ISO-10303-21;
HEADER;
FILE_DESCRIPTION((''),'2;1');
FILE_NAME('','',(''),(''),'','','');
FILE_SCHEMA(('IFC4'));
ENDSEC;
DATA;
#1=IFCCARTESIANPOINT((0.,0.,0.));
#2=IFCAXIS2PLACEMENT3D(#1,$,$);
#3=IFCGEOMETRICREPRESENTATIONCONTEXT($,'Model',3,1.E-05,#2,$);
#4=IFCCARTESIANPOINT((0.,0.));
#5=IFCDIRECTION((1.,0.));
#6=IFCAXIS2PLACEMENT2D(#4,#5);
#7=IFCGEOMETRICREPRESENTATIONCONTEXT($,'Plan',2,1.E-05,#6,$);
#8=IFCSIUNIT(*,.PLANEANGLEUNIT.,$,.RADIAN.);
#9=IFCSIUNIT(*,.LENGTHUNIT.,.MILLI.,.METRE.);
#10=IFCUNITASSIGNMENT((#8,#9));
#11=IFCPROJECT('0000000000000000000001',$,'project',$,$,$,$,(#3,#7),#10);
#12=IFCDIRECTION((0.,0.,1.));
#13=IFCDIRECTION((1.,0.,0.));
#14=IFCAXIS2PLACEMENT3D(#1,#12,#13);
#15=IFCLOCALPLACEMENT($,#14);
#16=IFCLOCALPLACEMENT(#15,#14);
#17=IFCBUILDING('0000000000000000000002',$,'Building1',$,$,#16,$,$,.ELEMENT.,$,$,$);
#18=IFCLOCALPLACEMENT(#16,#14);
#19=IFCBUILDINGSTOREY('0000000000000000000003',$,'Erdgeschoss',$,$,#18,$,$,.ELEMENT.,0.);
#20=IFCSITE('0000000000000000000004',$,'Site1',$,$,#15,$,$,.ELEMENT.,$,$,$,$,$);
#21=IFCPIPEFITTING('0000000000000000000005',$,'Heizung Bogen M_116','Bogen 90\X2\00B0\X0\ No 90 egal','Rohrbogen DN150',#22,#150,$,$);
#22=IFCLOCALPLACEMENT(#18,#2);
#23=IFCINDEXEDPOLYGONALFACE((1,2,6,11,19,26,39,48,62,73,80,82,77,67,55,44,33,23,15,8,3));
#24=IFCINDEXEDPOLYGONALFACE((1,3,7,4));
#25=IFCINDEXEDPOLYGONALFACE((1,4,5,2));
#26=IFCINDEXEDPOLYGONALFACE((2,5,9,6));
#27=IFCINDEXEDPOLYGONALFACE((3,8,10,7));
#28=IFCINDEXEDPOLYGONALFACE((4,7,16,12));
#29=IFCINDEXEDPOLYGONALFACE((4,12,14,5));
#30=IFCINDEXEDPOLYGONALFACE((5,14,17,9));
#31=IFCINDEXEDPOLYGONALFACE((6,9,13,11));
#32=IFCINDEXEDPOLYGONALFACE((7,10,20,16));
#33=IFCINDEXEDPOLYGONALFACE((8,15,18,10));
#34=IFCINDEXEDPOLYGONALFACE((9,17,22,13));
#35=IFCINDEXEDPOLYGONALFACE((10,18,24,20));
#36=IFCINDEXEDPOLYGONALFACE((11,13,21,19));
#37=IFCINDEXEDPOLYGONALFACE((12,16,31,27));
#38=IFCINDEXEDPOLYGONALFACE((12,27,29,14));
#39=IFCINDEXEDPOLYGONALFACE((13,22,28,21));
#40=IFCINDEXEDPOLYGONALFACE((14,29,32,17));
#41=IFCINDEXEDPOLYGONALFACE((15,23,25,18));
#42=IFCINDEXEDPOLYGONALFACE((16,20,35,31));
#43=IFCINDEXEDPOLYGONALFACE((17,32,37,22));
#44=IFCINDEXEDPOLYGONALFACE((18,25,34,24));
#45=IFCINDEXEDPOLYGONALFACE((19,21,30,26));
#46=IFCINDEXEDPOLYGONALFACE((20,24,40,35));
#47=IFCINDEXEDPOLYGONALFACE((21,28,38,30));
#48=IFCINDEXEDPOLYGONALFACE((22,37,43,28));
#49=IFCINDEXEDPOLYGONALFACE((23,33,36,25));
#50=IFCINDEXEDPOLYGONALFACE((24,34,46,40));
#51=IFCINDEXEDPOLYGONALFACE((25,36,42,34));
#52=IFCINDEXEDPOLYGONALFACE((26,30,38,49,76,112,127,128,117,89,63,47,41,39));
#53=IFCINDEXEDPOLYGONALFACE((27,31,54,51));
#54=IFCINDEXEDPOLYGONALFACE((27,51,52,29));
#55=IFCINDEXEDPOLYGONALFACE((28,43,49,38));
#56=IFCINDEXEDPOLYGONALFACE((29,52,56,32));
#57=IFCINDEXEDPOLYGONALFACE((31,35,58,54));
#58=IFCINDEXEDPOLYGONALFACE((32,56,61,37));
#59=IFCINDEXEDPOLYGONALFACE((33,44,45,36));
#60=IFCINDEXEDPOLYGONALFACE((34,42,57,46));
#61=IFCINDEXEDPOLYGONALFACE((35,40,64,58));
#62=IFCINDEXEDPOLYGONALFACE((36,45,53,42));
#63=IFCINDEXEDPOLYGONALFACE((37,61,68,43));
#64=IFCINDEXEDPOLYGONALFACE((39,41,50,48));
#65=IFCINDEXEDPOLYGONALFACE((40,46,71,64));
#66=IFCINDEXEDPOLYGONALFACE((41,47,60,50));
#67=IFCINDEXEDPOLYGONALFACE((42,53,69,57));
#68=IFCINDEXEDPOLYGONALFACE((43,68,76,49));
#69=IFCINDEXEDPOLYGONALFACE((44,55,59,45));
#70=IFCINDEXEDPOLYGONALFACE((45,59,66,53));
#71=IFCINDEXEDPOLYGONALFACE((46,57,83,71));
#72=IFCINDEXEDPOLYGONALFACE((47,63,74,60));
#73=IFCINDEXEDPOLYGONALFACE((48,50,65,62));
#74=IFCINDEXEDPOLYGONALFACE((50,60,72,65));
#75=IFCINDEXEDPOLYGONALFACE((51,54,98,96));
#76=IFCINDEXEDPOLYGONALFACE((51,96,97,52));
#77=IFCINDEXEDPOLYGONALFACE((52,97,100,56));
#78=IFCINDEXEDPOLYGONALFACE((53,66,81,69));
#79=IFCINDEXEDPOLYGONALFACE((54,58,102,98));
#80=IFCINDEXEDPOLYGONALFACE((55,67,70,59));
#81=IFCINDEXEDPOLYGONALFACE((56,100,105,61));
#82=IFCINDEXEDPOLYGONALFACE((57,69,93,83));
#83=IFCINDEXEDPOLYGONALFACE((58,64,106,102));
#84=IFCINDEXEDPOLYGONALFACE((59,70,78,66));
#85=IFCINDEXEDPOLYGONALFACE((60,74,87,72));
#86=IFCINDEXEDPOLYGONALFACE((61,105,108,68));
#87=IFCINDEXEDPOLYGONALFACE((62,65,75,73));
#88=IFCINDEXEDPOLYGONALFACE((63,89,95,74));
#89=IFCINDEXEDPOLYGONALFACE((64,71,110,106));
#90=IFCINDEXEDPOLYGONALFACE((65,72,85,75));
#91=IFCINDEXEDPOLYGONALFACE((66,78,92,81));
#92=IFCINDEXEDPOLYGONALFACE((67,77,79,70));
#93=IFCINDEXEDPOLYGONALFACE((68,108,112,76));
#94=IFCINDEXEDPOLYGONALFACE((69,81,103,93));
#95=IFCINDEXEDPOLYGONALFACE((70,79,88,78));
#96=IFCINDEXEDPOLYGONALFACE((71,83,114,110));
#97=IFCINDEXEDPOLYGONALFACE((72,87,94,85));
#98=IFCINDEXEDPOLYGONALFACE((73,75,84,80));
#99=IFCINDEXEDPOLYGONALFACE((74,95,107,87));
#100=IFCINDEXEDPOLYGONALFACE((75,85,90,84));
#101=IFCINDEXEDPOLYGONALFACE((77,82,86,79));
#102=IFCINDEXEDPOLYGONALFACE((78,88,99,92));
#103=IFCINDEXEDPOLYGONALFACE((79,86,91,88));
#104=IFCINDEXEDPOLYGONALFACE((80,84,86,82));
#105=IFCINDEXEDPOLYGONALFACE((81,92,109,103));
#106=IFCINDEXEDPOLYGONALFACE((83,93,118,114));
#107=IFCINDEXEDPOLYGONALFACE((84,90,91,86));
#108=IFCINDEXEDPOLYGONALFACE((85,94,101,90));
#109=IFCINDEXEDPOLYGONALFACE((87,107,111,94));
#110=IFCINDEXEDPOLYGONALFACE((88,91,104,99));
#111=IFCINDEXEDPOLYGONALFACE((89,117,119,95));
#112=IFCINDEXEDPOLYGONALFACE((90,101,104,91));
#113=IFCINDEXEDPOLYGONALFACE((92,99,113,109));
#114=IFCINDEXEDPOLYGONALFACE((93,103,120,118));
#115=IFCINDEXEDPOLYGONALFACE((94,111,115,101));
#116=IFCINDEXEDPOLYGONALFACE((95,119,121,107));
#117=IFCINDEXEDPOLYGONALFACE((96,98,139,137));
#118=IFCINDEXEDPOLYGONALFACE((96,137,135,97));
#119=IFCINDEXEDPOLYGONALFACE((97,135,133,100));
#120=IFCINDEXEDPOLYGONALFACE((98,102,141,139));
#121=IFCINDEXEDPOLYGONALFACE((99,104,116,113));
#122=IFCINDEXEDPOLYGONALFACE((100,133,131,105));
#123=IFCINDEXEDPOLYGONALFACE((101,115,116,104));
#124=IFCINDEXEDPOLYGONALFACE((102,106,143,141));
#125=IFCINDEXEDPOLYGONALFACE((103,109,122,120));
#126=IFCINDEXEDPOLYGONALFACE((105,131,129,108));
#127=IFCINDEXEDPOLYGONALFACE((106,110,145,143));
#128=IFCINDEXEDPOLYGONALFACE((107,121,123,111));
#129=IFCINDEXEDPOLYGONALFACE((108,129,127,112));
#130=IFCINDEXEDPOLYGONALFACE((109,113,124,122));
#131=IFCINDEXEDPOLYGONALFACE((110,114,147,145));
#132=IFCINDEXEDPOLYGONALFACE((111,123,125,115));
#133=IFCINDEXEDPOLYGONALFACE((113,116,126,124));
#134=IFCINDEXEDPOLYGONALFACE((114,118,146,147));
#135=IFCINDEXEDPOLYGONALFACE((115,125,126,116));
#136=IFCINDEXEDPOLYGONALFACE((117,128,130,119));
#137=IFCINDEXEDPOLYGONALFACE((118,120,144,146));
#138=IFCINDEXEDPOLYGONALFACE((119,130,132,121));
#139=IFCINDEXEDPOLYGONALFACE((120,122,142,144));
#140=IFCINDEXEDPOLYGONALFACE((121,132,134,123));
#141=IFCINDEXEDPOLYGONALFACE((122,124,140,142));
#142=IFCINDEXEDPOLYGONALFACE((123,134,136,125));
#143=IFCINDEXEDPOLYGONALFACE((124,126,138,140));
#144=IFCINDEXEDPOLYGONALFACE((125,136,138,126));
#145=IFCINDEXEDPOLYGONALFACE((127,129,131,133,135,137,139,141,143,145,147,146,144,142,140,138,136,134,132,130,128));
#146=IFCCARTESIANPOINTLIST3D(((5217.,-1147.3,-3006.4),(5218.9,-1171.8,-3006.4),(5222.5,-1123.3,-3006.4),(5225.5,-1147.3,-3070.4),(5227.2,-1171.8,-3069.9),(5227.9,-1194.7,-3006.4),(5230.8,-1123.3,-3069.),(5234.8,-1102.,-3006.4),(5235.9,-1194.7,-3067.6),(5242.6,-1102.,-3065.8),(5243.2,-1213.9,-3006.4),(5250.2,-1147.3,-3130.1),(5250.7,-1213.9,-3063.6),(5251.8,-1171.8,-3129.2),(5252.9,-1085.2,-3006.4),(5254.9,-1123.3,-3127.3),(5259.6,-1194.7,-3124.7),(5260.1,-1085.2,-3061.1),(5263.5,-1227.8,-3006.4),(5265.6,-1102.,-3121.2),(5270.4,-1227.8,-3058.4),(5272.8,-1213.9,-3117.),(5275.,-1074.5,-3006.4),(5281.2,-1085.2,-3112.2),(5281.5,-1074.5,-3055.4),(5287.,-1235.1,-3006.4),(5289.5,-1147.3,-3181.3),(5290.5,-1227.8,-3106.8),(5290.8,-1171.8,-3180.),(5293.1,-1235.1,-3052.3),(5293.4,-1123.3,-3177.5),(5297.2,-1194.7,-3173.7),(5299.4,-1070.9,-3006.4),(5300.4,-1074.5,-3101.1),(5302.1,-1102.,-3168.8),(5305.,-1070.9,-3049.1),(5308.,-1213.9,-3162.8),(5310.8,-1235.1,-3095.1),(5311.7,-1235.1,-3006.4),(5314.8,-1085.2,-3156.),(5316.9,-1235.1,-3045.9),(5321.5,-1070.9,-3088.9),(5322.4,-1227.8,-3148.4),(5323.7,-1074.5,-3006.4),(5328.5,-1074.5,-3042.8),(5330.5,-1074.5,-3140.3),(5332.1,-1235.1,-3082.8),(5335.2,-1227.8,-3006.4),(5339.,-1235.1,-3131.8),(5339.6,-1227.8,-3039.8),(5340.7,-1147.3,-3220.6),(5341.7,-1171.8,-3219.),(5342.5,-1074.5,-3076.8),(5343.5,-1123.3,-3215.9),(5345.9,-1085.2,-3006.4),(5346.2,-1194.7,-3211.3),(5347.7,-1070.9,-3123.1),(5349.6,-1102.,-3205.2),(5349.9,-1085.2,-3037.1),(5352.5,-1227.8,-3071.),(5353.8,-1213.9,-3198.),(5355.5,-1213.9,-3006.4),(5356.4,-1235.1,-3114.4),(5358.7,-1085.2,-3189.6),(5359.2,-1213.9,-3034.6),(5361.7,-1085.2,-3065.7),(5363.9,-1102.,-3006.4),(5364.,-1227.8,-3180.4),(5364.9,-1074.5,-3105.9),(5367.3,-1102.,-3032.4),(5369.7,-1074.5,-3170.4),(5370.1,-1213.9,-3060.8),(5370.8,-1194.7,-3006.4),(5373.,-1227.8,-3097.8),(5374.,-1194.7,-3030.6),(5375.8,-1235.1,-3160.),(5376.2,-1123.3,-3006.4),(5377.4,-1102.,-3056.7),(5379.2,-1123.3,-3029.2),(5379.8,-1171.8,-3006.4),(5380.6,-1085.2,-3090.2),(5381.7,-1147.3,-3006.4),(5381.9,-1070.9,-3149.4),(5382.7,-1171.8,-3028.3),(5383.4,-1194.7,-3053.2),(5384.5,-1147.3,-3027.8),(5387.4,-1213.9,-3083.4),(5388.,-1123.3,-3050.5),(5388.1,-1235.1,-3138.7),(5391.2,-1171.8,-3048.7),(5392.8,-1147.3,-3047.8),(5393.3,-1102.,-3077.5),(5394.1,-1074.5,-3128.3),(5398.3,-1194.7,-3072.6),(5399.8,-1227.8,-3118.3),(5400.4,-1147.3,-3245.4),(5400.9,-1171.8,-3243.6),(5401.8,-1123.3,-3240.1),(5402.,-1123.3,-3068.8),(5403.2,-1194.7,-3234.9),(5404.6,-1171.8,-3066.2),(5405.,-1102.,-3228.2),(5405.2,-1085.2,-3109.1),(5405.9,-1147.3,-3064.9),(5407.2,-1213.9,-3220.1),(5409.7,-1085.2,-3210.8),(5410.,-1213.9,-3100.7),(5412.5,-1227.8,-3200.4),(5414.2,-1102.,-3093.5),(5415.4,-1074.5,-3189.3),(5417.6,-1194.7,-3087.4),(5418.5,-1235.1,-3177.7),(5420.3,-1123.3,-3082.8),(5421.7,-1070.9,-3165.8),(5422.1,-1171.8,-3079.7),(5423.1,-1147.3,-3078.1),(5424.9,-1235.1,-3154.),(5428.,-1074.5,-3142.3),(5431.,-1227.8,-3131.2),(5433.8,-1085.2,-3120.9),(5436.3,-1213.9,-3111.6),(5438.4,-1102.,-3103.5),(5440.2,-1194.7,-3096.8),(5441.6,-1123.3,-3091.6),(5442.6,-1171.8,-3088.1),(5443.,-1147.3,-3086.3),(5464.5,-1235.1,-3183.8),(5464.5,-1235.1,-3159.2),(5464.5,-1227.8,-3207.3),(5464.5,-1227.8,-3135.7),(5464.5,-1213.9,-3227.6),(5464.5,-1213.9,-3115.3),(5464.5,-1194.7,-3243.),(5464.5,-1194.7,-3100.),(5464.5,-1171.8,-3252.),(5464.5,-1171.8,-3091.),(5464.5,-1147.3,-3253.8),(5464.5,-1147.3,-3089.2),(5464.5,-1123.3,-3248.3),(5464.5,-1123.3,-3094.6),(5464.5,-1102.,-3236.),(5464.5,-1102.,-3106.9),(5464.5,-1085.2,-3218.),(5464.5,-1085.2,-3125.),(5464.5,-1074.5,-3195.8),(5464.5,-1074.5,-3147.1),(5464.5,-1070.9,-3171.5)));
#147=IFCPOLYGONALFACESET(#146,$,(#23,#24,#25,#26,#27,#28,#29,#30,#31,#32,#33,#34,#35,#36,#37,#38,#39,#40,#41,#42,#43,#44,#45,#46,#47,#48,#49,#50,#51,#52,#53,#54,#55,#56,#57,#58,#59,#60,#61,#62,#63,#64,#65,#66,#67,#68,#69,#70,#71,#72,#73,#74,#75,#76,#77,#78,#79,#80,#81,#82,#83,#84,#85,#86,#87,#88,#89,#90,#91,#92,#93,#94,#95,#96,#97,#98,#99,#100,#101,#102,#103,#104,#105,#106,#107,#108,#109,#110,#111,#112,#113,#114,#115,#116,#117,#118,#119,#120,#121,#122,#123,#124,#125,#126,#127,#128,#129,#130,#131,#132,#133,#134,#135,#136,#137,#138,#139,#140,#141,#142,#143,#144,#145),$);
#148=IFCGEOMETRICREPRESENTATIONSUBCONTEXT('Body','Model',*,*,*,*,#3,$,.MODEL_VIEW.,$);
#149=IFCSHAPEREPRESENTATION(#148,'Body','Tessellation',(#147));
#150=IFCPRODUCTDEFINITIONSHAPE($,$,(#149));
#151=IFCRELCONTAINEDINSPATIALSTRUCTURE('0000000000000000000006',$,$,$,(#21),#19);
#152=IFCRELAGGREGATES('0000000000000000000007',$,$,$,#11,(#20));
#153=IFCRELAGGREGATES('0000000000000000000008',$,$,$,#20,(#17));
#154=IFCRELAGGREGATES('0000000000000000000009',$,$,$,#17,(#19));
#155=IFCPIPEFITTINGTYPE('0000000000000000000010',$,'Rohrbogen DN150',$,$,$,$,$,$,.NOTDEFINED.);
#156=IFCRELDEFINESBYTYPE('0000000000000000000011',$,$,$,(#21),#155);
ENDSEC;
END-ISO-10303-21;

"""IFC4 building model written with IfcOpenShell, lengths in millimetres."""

from ifc_helpers import new_model, entity, si_unit, frame, origin, origin_with_axes, origin_2d_with_axis, place, context, subcontext, project, spatial, source, transform, mapped, type_object, element, save


model = new_model("IFC4")

# Units and contexts
model_context = context("Model", 3, precision=1e-05, world=origin())
plan_context = context("Plan", 2, precision=1e-05, world=origin_2d_with_axis())
body_context = subcontext(model_context, "Body", "Model", "MODEL_VIEW")
ifc_project = project(units=[si_unit("PLANEANGLEUNIT", "RADIAN"), si_unit("LENGTHUNIT", "METRE", prefix="MILLI")], contexts=[model_context, plan_context])

# Site, building, storey
site_placement = place(None, origin_with_axes())
site = spatial("IfcSite", under=ifc_project, at=site_placement, Name="Site1", CompositionType="ELEMENT")
building_placement = place(site_placement, origin_with_axes())
building = spatial("IfcBuilding", under=site, at=building_placement, Name="Building1", CompositionType="ELEMENT")
storey_placement = place(building_placement, origin_with_axes())
storey = spatial("IfcBuildingStorey", under=building, at=storey_placement, Name="Erdgeschoss", CompositionType="ELEMENT", Elevation=0.0)

# Pipe fitting
pipe_fitting_type_1 = type_object("IfcPipeFittingType", Name="Rohrbogen DN150", PredefinedType="NOTDEFINED")
ifc_direction_1 = entity("IfcDirection", [-1.0, 0.0, 0.0])
shared_shape_1 = source(origin_with_axes(), body_context, "Body", "SolidModel", [
    entity("IfcRevolvedAreaSolid", entity("IfcCircleProfileDef", "AREA", None, entity("IfcAxis2Placement2D", entity("IfcCartesianPoint", [0.0, 0.0]), entity("IfcDirection", [1.0, 0.0])), 82.5), entity("IfcAxis2Placement3D", entity("IfcCartesianPoint", [123.8, -41.3, 0.0]), ifc_direction_1, entity("IfcDirection", [0.0, 0.0, 1.0])), entity("IfcAxis1Placement", entity("IfcCartesianPoint", [0.0, 165.1, 0.0]), ifc_direction_1), 1.570796),
])
pipe_fitting_1_placement = place(storey_placement, frame((5340.6, -1153.4, -3130.2), z_axis=(0.0, 0.0, 1.0), x_axis=(1.0, 0.0, 0.0)))
element("IfcPipeFitting", 1, at=pipe_fitting_1_placement, inside=storey, type_object=pipe_fitting_type_1, Name="Heizung Bogen M_116", Description="Bogen 90° No 90 egal", ObjectType="Rohrbogen DN150", context=body_context, shape_type="MappedRepresentation", body=[
    mapped(shared_shape_1, transform((0.0, 0.0, 0.0), x_axis=(0.0, 0.0, 1.0), y_axis=(1.0, 0.0, 0.0), z_axis=(0.0, 1.0, 0.0), scale=1.0)),
])

save(model, "model.ifc")
